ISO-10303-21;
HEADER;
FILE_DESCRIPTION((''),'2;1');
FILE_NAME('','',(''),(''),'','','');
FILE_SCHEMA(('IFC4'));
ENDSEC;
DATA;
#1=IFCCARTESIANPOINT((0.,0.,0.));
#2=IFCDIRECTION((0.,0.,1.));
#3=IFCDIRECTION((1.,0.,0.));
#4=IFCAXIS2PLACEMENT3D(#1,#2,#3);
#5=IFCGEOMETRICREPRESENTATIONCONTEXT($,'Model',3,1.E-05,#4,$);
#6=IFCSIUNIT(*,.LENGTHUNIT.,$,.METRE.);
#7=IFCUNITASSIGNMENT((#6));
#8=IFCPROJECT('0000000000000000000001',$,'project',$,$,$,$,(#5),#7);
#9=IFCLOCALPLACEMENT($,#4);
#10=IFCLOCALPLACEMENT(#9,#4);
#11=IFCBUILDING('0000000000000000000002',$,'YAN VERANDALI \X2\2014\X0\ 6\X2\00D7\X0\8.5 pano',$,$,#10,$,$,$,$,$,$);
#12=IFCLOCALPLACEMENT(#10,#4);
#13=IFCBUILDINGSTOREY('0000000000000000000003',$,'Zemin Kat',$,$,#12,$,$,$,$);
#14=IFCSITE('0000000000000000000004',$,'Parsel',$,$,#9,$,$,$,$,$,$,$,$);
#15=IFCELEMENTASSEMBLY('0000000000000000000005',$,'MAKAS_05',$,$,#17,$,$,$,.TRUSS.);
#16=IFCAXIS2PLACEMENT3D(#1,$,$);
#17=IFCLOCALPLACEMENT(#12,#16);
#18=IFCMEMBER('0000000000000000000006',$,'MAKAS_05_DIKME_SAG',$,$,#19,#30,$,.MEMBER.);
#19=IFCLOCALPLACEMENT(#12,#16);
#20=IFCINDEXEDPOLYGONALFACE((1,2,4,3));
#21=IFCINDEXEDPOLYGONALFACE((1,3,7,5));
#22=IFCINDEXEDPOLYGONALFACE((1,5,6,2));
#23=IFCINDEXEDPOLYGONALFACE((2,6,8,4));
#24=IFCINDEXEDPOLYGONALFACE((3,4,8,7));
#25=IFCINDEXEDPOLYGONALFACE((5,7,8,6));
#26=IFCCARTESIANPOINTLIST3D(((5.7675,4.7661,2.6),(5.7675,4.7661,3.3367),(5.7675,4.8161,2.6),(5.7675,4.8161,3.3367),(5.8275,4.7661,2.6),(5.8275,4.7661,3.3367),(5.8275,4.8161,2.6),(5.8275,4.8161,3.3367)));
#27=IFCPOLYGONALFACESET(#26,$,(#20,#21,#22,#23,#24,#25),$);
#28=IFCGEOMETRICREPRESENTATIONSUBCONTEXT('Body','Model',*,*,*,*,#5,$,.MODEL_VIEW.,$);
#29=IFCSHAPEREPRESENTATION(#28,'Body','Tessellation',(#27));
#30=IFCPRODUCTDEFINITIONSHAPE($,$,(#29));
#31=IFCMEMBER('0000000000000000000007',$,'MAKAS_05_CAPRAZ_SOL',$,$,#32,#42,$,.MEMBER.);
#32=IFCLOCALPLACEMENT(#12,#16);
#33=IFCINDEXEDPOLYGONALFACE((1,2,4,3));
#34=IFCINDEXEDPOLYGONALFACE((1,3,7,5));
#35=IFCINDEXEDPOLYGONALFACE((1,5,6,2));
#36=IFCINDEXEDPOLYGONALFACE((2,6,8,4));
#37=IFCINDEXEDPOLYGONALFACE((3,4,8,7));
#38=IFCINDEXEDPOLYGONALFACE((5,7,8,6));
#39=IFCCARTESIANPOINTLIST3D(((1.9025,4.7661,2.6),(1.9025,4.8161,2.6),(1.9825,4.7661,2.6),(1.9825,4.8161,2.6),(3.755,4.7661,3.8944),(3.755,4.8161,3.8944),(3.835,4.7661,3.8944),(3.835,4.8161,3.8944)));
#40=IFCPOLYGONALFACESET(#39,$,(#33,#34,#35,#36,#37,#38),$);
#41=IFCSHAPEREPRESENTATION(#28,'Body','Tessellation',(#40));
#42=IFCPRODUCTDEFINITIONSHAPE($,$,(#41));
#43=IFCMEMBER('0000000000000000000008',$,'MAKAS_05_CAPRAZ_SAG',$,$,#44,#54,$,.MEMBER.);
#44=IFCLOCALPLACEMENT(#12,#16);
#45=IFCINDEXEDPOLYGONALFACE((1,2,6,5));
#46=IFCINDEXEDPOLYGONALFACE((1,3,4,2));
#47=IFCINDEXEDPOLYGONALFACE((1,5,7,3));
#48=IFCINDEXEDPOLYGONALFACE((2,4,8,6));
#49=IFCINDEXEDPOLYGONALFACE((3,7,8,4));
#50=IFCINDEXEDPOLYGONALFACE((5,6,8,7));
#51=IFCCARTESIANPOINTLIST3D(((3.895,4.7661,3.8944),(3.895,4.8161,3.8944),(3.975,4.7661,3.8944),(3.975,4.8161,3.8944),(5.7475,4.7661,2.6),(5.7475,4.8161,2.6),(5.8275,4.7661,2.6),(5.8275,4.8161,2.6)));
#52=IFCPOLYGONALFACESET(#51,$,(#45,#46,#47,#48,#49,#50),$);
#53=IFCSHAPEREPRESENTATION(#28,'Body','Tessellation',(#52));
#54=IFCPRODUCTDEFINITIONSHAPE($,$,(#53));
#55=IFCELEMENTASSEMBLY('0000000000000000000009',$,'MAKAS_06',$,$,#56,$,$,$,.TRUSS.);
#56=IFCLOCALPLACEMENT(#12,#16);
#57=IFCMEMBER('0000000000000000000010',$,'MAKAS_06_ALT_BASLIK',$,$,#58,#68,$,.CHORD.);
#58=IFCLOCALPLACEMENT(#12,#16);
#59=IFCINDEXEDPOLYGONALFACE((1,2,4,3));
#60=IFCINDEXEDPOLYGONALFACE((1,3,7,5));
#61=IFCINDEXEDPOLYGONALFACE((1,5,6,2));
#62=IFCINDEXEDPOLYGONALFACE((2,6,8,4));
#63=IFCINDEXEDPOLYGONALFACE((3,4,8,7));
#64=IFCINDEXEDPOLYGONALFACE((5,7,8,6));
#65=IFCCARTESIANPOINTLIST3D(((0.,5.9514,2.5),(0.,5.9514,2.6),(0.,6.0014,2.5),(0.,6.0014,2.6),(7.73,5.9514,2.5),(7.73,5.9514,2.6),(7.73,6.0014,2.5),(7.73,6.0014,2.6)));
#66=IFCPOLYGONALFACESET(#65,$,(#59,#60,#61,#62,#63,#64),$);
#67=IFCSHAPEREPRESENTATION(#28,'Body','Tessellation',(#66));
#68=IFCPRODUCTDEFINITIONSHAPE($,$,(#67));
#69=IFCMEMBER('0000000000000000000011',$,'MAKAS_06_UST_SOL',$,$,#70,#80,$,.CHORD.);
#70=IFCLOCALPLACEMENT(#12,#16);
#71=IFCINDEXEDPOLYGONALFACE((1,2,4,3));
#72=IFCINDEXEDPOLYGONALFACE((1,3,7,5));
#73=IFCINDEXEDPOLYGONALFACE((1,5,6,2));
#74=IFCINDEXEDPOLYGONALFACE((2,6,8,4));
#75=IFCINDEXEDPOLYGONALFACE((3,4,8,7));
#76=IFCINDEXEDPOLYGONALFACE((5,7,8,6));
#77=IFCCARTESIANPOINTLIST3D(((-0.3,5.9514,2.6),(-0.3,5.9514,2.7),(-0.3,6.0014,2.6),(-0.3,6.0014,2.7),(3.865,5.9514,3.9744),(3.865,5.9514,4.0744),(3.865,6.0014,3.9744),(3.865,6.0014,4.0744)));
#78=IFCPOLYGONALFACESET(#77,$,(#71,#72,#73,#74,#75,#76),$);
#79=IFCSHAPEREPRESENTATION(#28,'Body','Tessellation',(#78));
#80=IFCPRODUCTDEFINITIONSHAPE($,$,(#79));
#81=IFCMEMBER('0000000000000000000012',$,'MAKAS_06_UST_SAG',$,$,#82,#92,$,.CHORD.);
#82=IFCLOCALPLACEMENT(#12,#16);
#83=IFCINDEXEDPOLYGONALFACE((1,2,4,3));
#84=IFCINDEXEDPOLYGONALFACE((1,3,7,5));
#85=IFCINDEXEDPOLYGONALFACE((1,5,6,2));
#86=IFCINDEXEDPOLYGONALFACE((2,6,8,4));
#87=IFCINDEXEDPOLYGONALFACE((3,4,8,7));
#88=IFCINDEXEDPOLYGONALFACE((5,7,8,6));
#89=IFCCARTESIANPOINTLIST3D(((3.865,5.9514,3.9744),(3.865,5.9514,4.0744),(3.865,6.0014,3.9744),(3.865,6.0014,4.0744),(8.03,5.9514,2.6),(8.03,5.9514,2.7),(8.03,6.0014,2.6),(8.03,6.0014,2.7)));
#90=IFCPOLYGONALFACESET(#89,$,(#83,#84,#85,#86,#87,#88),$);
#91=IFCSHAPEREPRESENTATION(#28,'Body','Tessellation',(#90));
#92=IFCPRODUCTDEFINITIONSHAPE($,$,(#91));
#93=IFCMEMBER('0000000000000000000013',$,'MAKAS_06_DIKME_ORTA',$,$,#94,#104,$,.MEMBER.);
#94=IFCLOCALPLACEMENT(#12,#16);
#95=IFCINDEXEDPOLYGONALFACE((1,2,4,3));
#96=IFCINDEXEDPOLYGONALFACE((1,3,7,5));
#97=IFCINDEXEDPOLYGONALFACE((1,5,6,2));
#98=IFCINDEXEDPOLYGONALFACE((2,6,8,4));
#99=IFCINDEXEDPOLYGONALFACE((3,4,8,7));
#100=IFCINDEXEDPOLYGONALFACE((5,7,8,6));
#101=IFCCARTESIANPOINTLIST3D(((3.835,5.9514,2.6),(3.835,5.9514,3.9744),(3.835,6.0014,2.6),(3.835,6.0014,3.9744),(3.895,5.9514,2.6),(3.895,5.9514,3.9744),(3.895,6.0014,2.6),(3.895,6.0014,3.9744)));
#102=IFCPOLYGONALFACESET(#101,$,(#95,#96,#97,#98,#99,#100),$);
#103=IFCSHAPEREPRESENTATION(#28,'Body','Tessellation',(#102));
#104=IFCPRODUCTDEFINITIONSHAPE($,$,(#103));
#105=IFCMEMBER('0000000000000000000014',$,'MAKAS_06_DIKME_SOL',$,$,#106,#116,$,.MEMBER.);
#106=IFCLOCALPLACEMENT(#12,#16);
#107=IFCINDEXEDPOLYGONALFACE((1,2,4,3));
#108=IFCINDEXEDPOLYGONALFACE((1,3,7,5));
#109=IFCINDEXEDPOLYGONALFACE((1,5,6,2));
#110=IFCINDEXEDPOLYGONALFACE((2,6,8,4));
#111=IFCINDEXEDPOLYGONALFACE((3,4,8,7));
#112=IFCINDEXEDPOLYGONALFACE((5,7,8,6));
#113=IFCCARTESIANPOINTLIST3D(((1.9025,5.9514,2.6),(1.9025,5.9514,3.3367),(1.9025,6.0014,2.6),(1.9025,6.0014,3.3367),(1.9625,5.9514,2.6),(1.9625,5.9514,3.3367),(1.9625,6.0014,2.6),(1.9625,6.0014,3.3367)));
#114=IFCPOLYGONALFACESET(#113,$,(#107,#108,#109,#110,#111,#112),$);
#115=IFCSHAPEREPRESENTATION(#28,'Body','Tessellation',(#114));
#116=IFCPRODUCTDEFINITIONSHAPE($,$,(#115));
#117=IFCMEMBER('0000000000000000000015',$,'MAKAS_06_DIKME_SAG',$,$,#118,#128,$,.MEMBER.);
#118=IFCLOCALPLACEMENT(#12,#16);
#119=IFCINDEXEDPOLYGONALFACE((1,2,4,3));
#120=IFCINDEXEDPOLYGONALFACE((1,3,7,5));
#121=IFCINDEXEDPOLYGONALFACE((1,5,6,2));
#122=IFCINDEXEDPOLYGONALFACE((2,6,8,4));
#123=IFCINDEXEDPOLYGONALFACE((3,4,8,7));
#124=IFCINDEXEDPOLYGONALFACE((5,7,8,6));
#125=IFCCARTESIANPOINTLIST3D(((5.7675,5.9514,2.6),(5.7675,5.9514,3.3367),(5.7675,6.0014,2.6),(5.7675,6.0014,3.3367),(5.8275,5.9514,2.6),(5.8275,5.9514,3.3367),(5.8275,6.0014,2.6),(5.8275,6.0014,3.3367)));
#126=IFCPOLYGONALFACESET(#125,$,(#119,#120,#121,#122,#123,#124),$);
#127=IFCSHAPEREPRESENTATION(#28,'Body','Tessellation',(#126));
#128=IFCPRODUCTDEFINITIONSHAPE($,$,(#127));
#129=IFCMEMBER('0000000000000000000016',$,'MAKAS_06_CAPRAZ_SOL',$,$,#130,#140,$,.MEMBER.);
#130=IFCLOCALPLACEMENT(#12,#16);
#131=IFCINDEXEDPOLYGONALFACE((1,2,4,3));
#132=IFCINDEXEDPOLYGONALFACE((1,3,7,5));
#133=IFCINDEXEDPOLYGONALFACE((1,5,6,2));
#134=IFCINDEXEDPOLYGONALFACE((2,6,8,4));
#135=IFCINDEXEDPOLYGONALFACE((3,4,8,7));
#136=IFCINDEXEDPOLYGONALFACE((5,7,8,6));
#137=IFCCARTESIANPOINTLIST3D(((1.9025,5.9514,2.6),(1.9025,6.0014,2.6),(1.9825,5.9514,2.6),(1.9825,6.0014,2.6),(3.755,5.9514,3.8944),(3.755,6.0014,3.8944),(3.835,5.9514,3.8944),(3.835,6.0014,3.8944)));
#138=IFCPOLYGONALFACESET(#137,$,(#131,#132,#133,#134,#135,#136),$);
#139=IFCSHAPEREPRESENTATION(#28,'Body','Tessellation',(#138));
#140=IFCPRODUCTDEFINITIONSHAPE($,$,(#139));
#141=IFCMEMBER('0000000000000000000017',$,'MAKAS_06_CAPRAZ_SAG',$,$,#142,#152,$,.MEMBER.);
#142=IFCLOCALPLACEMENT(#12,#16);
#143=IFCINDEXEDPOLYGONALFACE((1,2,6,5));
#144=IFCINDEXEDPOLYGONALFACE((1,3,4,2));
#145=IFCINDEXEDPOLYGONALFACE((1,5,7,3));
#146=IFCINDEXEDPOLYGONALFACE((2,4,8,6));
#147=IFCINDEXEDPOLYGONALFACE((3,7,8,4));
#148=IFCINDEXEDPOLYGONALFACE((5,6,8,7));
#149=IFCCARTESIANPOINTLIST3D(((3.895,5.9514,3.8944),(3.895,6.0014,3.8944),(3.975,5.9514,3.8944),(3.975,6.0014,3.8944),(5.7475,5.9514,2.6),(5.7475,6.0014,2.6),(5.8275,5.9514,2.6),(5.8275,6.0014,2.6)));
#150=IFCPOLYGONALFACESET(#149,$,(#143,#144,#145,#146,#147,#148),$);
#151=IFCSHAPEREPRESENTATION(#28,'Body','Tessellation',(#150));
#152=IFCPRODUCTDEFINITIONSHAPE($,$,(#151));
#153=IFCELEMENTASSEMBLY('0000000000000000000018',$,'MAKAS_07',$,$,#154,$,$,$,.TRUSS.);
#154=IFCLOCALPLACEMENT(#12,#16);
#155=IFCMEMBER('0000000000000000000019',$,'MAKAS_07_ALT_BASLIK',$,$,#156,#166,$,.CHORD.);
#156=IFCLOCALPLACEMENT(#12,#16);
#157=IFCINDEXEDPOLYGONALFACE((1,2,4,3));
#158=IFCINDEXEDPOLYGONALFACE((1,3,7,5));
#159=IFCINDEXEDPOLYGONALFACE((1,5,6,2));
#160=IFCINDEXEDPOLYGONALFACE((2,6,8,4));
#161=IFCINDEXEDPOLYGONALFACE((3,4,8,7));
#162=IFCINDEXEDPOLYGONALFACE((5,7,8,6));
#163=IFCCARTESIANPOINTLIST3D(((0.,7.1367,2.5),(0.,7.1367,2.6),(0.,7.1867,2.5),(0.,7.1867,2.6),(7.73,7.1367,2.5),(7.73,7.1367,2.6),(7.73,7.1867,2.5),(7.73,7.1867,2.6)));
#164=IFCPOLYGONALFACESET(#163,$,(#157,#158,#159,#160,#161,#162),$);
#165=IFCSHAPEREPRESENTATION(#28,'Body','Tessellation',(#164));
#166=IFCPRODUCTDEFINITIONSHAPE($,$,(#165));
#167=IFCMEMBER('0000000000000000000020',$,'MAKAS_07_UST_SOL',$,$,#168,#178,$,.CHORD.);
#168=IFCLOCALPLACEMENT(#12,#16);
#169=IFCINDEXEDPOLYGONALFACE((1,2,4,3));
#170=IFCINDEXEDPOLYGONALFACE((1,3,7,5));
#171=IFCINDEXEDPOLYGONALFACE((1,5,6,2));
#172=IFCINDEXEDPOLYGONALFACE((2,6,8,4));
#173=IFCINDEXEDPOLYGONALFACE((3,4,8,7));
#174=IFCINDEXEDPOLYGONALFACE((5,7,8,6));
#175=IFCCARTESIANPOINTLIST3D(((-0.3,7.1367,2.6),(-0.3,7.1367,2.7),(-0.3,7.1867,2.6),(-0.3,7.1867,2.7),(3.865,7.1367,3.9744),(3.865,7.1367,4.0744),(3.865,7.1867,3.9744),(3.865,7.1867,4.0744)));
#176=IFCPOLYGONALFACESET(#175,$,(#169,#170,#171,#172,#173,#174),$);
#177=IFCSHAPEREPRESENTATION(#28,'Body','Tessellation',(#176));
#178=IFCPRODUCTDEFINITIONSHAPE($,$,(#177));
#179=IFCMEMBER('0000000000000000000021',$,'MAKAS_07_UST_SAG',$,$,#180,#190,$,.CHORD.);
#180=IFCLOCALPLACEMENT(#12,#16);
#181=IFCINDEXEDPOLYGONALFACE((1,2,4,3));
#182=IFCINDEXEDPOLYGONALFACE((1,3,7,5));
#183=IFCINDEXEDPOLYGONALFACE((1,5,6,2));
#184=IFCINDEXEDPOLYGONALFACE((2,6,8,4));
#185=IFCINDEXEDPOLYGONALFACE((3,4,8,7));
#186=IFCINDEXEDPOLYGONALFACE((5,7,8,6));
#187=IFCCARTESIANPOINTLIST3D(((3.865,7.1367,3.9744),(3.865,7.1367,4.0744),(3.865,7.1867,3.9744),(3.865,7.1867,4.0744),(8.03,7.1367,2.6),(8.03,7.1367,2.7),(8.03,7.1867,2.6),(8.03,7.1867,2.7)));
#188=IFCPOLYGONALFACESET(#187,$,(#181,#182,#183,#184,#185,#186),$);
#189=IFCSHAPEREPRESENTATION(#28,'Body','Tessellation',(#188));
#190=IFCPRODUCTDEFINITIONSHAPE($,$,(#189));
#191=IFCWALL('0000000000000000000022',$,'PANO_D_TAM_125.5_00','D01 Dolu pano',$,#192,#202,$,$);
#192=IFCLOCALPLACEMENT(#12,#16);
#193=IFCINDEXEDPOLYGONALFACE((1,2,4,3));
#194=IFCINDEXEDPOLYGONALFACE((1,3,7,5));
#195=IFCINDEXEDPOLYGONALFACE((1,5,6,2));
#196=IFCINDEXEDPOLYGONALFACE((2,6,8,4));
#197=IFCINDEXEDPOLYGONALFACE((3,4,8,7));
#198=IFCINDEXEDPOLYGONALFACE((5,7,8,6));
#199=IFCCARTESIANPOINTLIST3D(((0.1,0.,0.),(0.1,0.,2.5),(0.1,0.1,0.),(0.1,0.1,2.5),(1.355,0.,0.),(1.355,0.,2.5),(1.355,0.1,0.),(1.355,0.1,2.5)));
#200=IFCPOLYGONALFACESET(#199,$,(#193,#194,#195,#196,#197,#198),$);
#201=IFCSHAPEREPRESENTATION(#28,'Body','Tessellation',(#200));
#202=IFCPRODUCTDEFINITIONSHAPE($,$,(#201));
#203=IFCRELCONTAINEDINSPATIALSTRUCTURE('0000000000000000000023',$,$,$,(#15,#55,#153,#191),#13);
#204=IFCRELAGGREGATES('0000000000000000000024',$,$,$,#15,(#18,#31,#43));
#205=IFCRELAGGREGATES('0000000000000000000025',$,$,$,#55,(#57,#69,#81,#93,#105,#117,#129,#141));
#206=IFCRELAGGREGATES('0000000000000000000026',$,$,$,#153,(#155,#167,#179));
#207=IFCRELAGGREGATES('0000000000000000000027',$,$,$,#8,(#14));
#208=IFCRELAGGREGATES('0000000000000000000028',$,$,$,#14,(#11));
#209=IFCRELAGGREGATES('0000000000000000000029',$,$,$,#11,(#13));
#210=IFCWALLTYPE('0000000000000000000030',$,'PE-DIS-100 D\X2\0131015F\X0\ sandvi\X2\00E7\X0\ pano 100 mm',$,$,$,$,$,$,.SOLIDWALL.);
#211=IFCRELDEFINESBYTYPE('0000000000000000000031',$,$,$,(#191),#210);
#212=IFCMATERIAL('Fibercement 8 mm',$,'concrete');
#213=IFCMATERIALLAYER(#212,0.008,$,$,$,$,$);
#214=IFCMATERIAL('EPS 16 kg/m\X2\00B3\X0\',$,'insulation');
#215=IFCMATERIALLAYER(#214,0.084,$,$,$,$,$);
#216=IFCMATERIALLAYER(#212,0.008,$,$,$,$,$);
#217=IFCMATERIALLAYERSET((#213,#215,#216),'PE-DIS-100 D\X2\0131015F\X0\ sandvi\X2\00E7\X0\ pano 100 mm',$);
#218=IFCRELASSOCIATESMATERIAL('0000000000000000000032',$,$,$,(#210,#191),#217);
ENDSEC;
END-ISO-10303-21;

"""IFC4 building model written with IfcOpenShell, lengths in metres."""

from ifc_helpers import new_model, si_unit, frame, origin_with_axes, place, context, subcontext, project, spatial, line, indexed_curve, outline, extrude, material, layer, layer_set, layer_usage, type_object, element, aggregate, save


model = new_model("IFC4")

# Units and contexts
model_context = context("Model", 3, precision=1e-05, world=origin_with_axes())
body_context = subcontext(model_context, "Body", "Model", "MODEL_VIEW")
ifc_project = project(units=[si_unit("LENGTHUNIT", "METRE")], contexts=[model_context])

# Site, building, storey
site_placement = place(None, origin_with_axes())
site = spatial("IfcSite", under=ifc_project, at=site_placement, Name="Parsel")
building_placement = place(site_placement, origin_with_axes())
building = spatial("IfcBuilding", under=site, at=building_placement, Name="YAN VERANDALI — 6×8.5 pano")
storey_placement = place(building_placement, origin_with_axes())
storey = spatial("IfcBuildingStorey", under=building, at=storey_placement, Name="Zemin Kat")

# Element assemblies, members
assembly_1_placement = place(storey_placement, origin_with_axes())
assembly_1 = element("IfcElementAssembly", 1, at=assembly_1_placement, inside=storey, Name="MAKAS_05", PredefinedType="TRUSS")
member_1_placement = place(assembly_1_placement, origin_with_axes())
member_1 = element("IfcMember", 2, at=member_1_placement, Name="MAKAS_05_DIKME_SAG", PredefinedType="MEMBER", context=body_context, shape_type="SweptSolid", body=[
    extrude(outline(indexed_curve([(5.7675, 2.6), (5.8275, 2.6), (5.8275, 3.3367), (5.7675, 3.3367)], segments=[line(1, 2, 3, 4, 1)])), frame((0.0, 4.8161, 0.0), z_axis=(0.0, -1.0, 0.0), x_axis=(1.0, 0.0, 0.0)), (0.0, 0.0, 1.0), 0.05),
])
member_2_placement = place(assembly_1_placement, origin_with_axes())
member_2 = element("IfcMember", 3, at=member_2_placement, Name="MAKAS_05_CAPRAZ_SOL", PredefinedType="MEMBER", context=body_context, shape_type="SweptSolid", body=[
    extrude(outline(indexed_curve([(1.9025, 2.6), (1.9825, 2.6), (3.835, 3.8944), (3.755, 3.8944)], segments=[line(1, 2, 3, 4, 1)])), frame((0.0, 4.8161, 0.0), z_axis=(0.0, -1.0, 0.0), x_axis=(1.0, 0.0, 0.0)), (0.0, 0.0, 1.0), 0.05),
])
member_3_placement = place(assembly_1_placement, origin_with_axes())
member_3 = element("IfcMember", 4, at=member_3_placement, Name="MAKAS_05_CAPRAZ_SAG", PredefinedType="MEMBER", context=body_context, shape_type="SweptSolid", body=[
    extrude(outline(indexed_curve([(5.7475, 2.6), (5.8275, 2.6), (3.975, 3.8944), (3.895, 3.8944)], segments=[line(1, 2, 3, 4, 1)])), frame((0.0, 4.8161, 0.0), z_axis=(0.0, -1.0, 0.0), x_axis=(1.0, 0.0, 0.0)), (0.0, 0.0, 1.0), 0.05),
])
aggregate(assembly_1, [member_1, member_2, member_3])
assembly_2_placement = place(storey_placement, origin_with_axes())
assembly_2 = element("IfcElementAssembly", 5, at=assembly_2_placement, inside=storey, Name="MAKAS_06", PredefinedType="TRUSS")
member_4_placement = place(assembly_2_placement, origin_with_axes())
member_4 = element("IfcMember", 6, at=member_4_placement, Name="MAKAS_06_ALT_BASLIK", PredefinedType="CHORD", context=body_context, shape_type="SweptSolid", body=[
    extrude(outline(indexed_curve([(0.0, 2.5), (7.73, 2.5), (7.73, 2.6), (0.0, 2.6)], segments=[line(1, 2, 3, 4, 1)])), frame((0.0, 6.0014, 0.0), z_axis=(0.0, -1.0, 0.0), x_axis=(1.0, 0.0, 0.0)), (0.0, 0.0, 1.0), 0.05),
])
member_5_placement = place(assembly_2_placement, origin_with_axes())
member_5 = element("IfcMember", 7, at=member_5_placement, Name="MAKAS_06_UST_SOL", PredefinedType="CHORD", context=body_context, shape_type="SweptSolid", body=[
    extrude(outline(indexed_curve([(-0.3, 2.6), (3.865, 3.9745), (3.865, 4.0744), (-0.3, 2.7)], segments=[line(1, 2, 3, 4, 1)])), frame((0.0, 6.0014, 0.0), z_axis=(0.0, -1.0, 0.0), x_axis=(1.0, 0.0, 0.0)), (0.0, 0.0, 1.0), 0.05),
])
member_6_placement = place(assembly_2_placement, origin_with_axes())
member_6 = element("IfcMember", 8, at=member_6_placement, Name="MAKAS_06_UST_SAG", PredefinedType="CHORD", context=body_context, shape_type="SweptSolid", body=[
    extrude(outline(indexed_curve([(3.865, 3.9745), (8.03, 2.6), (8.03, 2.7), (3.865, 4.0744)], segments=[line(1, 2, 3, 4, 1)])), frame((0.0, 6.0014, 0.0), z_axis=(0.0, -1.0, 0.0), x_axis=(1.0, 0.0, 0.0)), (0.0, 0.0, 1.0), 0.05),
])
member_7_placement = place(assembly_2_placement, origin_with_axes())
member_7 = element("IfcMember", 9, at=member_7_placement, Name="MAKAS_06_DIKME_ORTA", PredefinedType="MEMBER", context=body_context, shape_type="SweptSolid", body=[
    extrude(outline(indexed_curve([(3.835, 2.6), (3.895, 2.6), (3.895, 3.9745), (3.835, 3.9745)], segments=[line(1, 2, 3, 4, 1)])), frame((0.0, 6.0014, 0.0), z_axis=(0.0, -1.0, 0.0), x_axis=(1.0, 0.0, 0.0)), (0.0, 0.0, 1.0), 0.05),
])
member_8_placement = place(assembly_2_placement, origin_with_axes())
member_8 = element("IfcMember", 10, at=member_8_placement, Name="MAKAS_06_DIKME_SOL", PredefinedType="MEMBER", context=body_context, shape_type="SweptSolid", body=[
    extrude(outline(indexed_curve([(1.9025, 2.6), (1.9625, 2.6), (1.9625, 3.3367), (1.9025, 3.3367)], segments=[line(1, 2, 3, 4, 1)])), frame((0.0, 6.0014, 0.0), z_axis=(0.0, -1.0, 0.0), x_axis=(1.0, 0.0, 0.0)), (0.0, 0.0, 1.0), 0.05),
])
member_9_placement = place(assembly_2_placement, origin_with_axes())
member_9 = element("IfcMember", 11, at=member_9_placement, Name="MAKAS_06_DIKME_SAG", PredefinedType="MEMBER", context=body_context, shape_type="SweptSolid", body=[
    extrude(outline(indexed_curve([(5.7675, 2.6), (5.8275, 2.6), (5.8275, 3.3367), (5.7675, 3.3367)], segments=[line(1, 2, 3, 4, 1)])), frame((0.0, 6.0014, 0.0), z_axis=(0.0, -1.0, 0.0), x_axis=(1.0, 0.0, 0.0)), (0.0, 0.0, 1.0), 0.05),
])
member_10_placement = place(assembly_2_placement, origin_with_axes())
member_10 = element("IfcMember", 12, at=member_10_placement, Name="MAKAS_06_CAPRAZ_SOL", PredefinedType="MEMBER", context=body_context, shape_type="SweptSolid", body=[
    extrude(outline(indexed_curve([(1.9025, 2.6), (1.9825, 2.6), (3.835, 3.8944), (3.755, 3.8944)], segments=[line(1, 2, 3, 4, 1)])), frame((0.0, 6.0014, 0.0), z_axis=(0.0, -1.0, 0.0), x_axis=(1.0, 0.0, 0.0)), (0.0, 0.0, 1.0), 0.05),
])
member_11_placement = place(assembly_2_placement, origin_with_axes())
member_11 = element("IfcMember", 13, at=member_11_placement, Name="MAKAS_06_CAPRAZ_SAG", PredefinedType="MEMBER", context=body_context, shape_type="SweptSolid", body=[
    extrude(outline(indexed_curve([(5.7475, 2.6), (5.8275, 2.6), (3.975, 3.8944), (3.895, 3.8944)], segments=[line(1, 2, 3, 4, 1)])), frame((0.0, 6.0014, 0.0), z_axis=(0.0, -1.0, 0.0), x_axis=(1.0, 0.0, 0.0)), (0.0, 0.0, 1.0), 0.05),
])
aggregate(assembly_2, [member_4, member_5, member_6, member_7, member_8, member_9, member_10, member_11])
assembly_3_placement = place(storey_placement, origin_with_axes())
assembly_3 = element("IfcElementAssembly", 14, at=assembly_3_placement, inside=storey, Name="MAKAS_07", PredefinedType="TRUSS")
member_12_placement = place(assembly_3_placement, origin_with_axes())
member_12 = element("IfcMember", 15, at=member_12_placement, Name="MAKAS_07_ALT_BASLIK", PredefinedType="CHORD", context=body_context, shape_type="SweptSolid", body=[
    extrude(outline(indexed_curve([(0.0, 2.5), (7.73, 2.5), (7.73, 2.6), (0.0, 2.6)], segments=[line(1, 2, 3, 4, 1)])), frame((0.0, 7.1867, 0.0), z_axis=(0.0, -1.0, 0.0), x_axis=(1.0, 0.0, 0.0)), (0.0, 0.0, 1.0), 0.05),
])
member_13_placement = place(assembly_3_placement, origin_with_axes())
member_13 = element("IfcMember", 16, at=member_13_placement, Name="MAKAS_07_UST_SOL", PredefinedType="CHORD", context=body_context, shape_type="SweptSolid", body=[
    extrude(outline(indexed_curve([(-0.3, 2.6), (3.865, 3.9745), (3.865, 4.0744), (-0.3, 2.7)], segments=[line(1, 2, 3, 4, 1)])), frame((0.0, 7.1867, 0.0), z_axis=(0.0, -1.0, 0.0), x_axis=(1.0, 0.0, 0.0)), (0.0, 0.0, 1.0), 0.05),
])
member_14_placement = place(assembly_3_placement, origin_with_axes())
member_14 = element("IfcMember", 17, at=member_14_placement, Name="MAKAS_07_UST_SAG", PredefinedType="CHORD", context=body_context, shape_type="SweptSolid", body=[
    extrude(outline(indexed_curve([(3.865, 3.9745), (8.03, 2.6), (8.03, 2.7), (3.865, 4.0744)], segments=[line(1, 2, 3, 4, 1)])), frame((0.0, 7.1867, 0.0), z_axis=(0.0, -1.0, 0.0), x_axis=(1.0, 0.0, 0.0)), (0.0, 0.0, 1.0), 0.05),
])
aggregate(assembly_3, [member_12, member_13, member_14])

# Wall
ifc_material_1 = material(Name="Fibercement 8 mm", Category="concrete")
ifc_layer_1 = layer(ifc_material_1, 0.008)
ifc_material_2 = material(Name="EPS 16 kg/m³", Category="insulation")
ifc_layer_2 = layer(ifc_material_2, 0.084)
ifc_layer_3 = layer(ifc_material_1, 0.008)
ifc_layer_set = layer_set([ifc_layer_1, ifc_layer_2, ifc_layer_3], Name="PE-DIS-100 Dış sandviç pano 100 mm")
ifc_layer_usage_1 = layer_usage(ifc_layer_set, "AXIS2", "POSITIVE", 0.0)
wall_type = type_object("IfcWallType", Name="PE-DIS-100 Dış sandviç pano 100 mm", PredefinedType="SOLIDWALL", material=ifc_layer_set)
wall_1_placement = place(storey_placement, frame((0.1, 0.0, 0.0), z_axis=(0.0, 0.0, 1.0), x_axis=(1.0, 0.0, 0.0)))
element("IfcWall", 18, at=wall_1_placement, inside=storey, type_object=wall_type, material=ifc_layer_usage_1, Name="PANO_D_TAM_125.5_00", Description="D01 Dolu pano", context=body_context, shape_type="SweptSolid", body=[
    extrude(outline(indexed_curve([(0.0, 0.0), (1.255, 0.0), (1.255, 0.1), (0.0, 0.1)], segments=[line(1, 2, 3, 4, 1)])), origin_with_axes(), (0.0, 0.0, 1.0), 2.5),
])

save(model, "model.ifc")
